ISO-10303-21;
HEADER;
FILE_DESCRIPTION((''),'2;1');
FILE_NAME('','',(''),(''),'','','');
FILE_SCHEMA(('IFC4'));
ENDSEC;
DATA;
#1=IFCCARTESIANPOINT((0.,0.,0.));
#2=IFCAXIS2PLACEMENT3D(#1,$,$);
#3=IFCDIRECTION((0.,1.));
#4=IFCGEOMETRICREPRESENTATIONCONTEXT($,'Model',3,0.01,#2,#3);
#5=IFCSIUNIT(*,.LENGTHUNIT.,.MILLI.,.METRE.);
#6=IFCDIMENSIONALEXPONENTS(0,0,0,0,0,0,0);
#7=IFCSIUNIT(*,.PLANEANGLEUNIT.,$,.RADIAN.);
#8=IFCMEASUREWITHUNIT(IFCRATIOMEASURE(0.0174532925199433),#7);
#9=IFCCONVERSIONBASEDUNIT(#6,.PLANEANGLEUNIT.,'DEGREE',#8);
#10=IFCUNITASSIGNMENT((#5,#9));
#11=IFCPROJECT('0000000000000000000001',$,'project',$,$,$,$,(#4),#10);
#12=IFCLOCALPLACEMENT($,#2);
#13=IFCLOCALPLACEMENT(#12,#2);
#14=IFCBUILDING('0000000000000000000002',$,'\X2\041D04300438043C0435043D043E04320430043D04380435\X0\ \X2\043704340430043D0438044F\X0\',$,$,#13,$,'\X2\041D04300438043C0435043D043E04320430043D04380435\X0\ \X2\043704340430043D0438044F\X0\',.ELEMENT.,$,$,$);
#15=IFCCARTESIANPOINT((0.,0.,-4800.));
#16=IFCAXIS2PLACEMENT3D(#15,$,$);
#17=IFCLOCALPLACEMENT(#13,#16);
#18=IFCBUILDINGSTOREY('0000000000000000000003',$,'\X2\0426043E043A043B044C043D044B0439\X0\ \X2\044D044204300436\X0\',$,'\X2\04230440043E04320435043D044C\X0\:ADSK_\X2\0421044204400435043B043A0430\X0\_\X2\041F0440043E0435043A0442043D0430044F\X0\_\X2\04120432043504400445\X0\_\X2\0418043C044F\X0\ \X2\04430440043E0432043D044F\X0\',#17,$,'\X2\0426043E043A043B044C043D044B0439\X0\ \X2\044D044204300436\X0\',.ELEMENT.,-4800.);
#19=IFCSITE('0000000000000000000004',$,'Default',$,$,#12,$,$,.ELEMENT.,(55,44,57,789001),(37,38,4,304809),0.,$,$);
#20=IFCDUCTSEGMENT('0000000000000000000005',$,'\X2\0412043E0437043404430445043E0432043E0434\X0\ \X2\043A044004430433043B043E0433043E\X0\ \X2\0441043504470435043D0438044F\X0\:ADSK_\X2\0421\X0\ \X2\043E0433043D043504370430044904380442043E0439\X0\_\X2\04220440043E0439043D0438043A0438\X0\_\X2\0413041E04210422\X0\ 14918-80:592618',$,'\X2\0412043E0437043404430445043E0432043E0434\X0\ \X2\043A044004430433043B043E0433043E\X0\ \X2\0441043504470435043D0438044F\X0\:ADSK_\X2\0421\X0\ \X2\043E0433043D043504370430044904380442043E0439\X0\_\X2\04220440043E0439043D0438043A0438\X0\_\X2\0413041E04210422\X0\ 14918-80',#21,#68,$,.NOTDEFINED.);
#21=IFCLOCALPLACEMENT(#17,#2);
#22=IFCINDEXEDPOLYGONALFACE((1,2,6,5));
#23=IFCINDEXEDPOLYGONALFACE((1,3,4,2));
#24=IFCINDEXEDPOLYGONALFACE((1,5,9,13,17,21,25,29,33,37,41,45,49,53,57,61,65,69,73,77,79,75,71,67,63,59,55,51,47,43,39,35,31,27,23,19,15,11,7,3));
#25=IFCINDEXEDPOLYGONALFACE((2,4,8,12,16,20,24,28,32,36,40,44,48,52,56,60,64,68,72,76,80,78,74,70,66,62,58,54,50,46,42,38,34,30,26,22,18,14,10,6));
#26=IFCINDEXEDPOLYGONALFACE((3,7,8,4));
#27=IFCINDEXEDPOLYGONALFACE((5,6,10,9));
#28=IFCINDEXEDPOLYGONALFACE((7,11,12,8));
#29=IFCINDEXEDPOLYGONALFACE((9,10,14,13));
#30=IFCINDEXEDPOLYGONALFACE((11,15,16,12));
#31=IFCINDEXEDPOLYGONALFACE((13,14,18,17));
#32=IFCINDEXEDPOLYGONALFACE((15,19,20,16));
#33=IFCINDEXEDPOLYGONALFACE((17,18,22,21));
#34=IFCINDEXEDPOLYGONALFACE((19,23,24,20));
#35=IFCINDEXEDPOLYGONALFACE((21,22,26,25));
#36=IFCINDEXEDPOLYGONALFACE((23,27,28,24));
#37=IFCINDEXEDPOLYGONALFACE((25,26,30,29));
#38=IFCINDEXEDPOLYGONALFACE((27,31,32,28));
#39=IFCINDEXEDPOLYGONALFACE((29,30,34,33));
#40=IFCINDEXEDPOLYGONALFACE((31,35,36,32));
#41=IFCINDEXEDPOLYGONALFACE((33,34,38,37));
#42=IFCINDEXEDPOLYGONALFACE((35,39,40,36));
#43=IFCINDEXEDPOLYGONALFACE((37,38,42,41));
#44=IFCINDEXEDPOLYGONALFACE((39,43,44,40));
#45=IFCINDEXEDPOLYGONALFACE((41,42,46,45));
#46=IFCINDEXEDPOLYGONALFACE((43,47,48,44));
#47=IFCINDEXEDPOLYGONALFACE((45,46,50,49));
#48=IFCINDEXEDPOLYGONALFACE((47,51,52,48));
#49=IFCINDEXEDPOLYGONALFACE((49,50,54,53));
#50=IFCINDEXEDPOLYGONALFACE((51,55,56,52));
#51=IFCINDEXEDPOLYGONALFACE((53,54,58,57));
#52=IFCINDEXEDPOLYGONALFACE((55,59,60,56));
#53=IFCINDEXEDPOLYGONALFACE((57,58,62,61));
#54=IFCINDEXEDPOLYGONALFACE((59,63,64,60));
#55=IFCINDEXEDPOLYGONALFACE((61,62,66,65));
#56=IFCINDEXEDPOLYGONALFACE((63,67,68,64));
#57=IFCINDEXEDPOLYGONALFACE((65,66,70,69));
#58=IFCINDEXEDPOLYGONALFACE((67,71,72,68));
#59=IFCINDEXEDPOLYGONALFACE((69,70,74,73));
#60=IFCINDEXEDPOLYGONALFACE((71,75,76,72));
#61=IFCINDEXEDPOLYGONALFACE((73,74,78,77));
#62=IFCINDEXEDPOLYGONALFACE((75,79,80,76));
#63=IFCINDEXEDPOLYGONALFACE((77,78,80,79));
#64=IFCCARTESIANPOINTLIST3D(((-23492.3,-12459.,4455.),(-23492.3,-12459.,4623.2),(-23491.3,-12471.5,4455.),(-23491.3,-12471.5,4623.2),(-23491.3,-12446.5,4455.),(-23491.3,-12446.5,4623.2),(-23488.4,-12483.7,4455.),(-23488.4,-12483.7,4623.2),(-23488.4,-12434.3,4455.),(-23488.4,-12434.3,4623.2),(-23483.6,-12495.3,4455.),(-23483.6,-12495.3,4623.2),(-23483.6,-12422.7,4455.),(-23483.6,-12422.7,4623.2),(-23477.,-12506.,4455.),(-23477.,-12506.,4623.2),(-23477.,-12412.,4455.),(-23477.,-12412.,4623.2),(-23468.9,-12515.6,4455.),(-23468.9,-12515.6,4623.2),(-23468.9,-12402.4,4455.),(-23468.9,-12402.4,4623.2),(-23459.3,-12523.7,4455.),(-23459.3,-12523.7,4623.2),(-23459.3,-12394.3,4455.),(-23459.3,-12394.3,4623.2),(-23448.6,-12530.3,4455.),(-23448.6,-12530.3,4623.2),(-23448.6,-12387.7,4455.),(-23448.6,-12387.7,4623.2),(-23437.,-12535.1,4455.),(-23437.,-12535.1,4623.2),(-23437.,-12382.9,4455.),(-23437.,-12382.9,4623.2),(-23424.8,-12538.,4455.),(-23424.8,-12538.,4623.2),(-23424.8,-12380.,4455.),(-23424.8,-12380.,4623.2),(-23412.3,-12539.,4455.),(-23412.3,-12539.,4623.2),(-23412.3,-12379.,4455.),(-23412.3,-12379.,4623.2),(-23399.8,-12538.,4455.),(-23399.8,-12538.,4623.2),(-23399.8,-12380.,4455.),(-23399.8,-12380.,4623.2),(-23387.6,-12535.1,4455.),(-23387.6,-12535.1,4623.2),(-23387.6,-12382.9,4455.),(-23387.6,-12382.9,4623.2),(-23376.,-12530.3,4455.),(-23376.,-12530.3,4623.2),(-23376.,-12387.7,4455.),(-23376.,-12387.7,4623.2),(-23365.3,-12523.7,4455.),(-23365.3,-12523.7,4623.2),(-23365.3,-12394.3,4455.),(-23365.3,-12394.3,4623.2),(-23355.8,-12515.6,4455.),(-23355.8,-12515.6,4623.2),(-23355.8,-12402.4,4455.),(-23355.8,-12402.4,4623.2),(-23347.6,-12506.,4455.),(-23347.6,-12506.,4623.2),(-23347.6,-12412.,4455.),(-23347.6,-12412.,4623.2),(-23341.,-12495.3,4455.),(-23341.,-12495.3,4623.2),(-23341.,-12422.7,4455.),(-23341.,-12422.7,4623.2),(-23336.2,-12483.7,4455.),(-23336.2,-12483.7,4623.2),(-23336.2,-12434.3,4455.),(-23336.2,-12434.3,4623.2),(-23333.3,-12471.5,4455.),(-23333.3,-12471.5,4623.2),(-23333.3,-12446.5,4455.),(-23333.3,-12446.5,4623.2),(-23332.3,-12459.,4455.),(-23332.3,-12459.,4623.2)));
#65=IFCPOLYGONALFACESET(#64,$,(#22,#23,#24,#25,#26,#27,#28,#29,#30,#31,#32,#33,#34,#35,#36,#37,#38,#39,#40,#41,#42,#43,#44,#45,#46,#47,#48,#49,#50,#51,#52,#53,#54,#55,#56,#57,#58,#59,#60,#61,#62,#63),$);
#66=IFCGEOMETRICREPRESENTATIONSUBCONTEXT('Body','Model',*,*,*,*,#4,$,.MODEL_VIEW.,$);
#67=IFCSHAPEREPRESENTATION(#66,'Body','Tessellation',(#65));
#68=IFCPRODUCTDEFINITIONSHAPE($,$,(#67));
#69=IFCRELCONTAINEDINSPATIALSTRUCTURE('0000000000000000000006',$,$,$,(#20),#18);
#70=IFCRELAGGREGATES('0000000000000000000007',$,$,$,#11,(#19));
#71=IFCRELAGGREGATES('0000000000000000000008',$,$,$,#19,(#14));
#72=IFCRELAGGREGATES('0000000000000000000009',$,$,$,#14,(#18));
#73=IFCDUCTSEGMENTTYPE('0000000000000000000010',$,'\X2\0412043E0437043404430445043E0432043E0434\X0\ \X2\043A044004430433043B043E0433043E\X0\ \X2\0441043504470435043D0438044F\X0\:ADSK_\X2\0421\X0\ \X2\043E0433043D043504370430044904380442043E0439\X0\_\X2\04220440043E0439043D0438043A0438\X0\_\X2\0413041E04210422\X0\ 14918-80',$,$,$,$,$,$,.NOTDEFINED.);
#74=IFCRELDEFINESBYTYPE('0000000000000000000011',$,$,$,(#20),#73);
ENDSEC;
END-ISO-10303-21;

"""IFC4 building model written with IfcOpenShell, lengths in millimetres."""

from ifc_helpers import new_model, entity, si_unit, converted_unit, direction, frame, origin, place, context, subcontext, project, spatial, indexed_curve, outline, extrude, type_object, element, save


model = new_model("IFC4")

# Units and contexts
model_context = context("Model", 3, precision=0.01, world=origin(), true_north=direction((0.0, 1.0)))
body_context = subcontext(model_context, "Body", "Model", "MODEL_VIEW")
ifc_project = project(units=[si_unit("LENGTHUNIT", "METRE", prefix="MILLI"), converted_unit("PLANEANGLEUNIT", "DEGREE", entity("IfcRatioMeasure", 0.0174532925199433), si_unit("PLANEANGLEUNIT", "RADIAN"), dimensions=[0, 0, 0, 0, 0, 0, 0])], contexts=[model_context])

# Site, building, storey
site_placement = place(None, origin())
site = spatial("IfcSite", under=ifc_project, at=site_placement, Name="Default", CompositionType="ELEMENT", RefLatitude=(55, 44, 57, 789001), RefLongitude=(37, 38, 4, 304809), RefElevation=0.0)
building_placement = place(site_placement, origin())
building = spatial("IfcBuilding", under=site, at=building_placement, Name="Наименование здания", LongName="Наименование здания", CompositionType="ELEMENT")
storey_placement = place(building_placement, frame((0.0, 0.0, -4800.0)))
storey = spatial("IfcBuildingStorey", under=building, at=storey_placement, Name="Цокльный этаж", ObjectType="Уровень:ADSK_Стрелка_Проектная_Вверх_Имя уровня", LongName="Цокльный этаж", CompositionType="ELEMENT", Elevation=-4800.0)

# Duct segment
duct_segment_type = type_object("IfcDuctSegmentType", Name="Воздуховод круглого сечения:ADSK_С огнезащитой_Тройники_ГОСТ 14918-80", PredefinedType="NOTDEFINED")
duct_segment_1_placement = place(storey_placement, origin())
element("IfcDuctSegment", 1, at=duct_segment_1_placement, inside=storey, type_object=duct_segment_type, Name="Воздуховод круглого сечения:ADSK_С огнезащитой_Тройники_ГОСТ 14918-80:592618", ObjectType="Воздуховод круглого сечения:ADSK_С огнезащитой_Тройники_ГОСТ 14918-80", PredefinedType="NOTDEFINED", context=body_context, shape_type="SweptSolid", body=[
    extrude(outline(indexed_curve([(80.0, 0.0), (79.0, 12.5), (76.1, 24.7), (71.3, 36.3), (64.7, 47.0), (56.6, 56.6), (47.0, 64.7), (36.3, 71.3), (24.7, 76.1), (12.5, 79.0), (0.0, 80.0), (-12.5, 79.0), (-24.7, 76.1), (-36.3, 71.3), (-47.0, 64.7), (-56.6, 56.6), (-64.7, 47.0), (-71.3, 36.3), (-76.1, 24.7), (-79.0, 12.5), (-80.0, 0.0), (-79.0, -12.5), (-76.1, -24.7), (-71.3, -36.3), (-64.7, -47.0), (-56.6, -56.6), (-47.0, -64.7), (-36.3, -71.3), (-24.7, -76.1), (-12.5, -79.0), (0.0, -80.0), (12.5, -79.0), (24.7, -76.1), (36.3, -71.3), (47.0, -64.7), (56.6, -56.6), (64.7, -47.0), (71.3, -36.3), (76.1, -24.7), (79.0, -12.5), (80.0, 0.0)], self_intersect=False)), frame((-23412.3, -12459.0, 4455.0), z_axis=(0.0, 0.0, 1.0), x_axis=(0.0, -1.0, 0.0)), (0.0, 0.0, 1.0), 168.2),
])

save(model, "model.ifc")
